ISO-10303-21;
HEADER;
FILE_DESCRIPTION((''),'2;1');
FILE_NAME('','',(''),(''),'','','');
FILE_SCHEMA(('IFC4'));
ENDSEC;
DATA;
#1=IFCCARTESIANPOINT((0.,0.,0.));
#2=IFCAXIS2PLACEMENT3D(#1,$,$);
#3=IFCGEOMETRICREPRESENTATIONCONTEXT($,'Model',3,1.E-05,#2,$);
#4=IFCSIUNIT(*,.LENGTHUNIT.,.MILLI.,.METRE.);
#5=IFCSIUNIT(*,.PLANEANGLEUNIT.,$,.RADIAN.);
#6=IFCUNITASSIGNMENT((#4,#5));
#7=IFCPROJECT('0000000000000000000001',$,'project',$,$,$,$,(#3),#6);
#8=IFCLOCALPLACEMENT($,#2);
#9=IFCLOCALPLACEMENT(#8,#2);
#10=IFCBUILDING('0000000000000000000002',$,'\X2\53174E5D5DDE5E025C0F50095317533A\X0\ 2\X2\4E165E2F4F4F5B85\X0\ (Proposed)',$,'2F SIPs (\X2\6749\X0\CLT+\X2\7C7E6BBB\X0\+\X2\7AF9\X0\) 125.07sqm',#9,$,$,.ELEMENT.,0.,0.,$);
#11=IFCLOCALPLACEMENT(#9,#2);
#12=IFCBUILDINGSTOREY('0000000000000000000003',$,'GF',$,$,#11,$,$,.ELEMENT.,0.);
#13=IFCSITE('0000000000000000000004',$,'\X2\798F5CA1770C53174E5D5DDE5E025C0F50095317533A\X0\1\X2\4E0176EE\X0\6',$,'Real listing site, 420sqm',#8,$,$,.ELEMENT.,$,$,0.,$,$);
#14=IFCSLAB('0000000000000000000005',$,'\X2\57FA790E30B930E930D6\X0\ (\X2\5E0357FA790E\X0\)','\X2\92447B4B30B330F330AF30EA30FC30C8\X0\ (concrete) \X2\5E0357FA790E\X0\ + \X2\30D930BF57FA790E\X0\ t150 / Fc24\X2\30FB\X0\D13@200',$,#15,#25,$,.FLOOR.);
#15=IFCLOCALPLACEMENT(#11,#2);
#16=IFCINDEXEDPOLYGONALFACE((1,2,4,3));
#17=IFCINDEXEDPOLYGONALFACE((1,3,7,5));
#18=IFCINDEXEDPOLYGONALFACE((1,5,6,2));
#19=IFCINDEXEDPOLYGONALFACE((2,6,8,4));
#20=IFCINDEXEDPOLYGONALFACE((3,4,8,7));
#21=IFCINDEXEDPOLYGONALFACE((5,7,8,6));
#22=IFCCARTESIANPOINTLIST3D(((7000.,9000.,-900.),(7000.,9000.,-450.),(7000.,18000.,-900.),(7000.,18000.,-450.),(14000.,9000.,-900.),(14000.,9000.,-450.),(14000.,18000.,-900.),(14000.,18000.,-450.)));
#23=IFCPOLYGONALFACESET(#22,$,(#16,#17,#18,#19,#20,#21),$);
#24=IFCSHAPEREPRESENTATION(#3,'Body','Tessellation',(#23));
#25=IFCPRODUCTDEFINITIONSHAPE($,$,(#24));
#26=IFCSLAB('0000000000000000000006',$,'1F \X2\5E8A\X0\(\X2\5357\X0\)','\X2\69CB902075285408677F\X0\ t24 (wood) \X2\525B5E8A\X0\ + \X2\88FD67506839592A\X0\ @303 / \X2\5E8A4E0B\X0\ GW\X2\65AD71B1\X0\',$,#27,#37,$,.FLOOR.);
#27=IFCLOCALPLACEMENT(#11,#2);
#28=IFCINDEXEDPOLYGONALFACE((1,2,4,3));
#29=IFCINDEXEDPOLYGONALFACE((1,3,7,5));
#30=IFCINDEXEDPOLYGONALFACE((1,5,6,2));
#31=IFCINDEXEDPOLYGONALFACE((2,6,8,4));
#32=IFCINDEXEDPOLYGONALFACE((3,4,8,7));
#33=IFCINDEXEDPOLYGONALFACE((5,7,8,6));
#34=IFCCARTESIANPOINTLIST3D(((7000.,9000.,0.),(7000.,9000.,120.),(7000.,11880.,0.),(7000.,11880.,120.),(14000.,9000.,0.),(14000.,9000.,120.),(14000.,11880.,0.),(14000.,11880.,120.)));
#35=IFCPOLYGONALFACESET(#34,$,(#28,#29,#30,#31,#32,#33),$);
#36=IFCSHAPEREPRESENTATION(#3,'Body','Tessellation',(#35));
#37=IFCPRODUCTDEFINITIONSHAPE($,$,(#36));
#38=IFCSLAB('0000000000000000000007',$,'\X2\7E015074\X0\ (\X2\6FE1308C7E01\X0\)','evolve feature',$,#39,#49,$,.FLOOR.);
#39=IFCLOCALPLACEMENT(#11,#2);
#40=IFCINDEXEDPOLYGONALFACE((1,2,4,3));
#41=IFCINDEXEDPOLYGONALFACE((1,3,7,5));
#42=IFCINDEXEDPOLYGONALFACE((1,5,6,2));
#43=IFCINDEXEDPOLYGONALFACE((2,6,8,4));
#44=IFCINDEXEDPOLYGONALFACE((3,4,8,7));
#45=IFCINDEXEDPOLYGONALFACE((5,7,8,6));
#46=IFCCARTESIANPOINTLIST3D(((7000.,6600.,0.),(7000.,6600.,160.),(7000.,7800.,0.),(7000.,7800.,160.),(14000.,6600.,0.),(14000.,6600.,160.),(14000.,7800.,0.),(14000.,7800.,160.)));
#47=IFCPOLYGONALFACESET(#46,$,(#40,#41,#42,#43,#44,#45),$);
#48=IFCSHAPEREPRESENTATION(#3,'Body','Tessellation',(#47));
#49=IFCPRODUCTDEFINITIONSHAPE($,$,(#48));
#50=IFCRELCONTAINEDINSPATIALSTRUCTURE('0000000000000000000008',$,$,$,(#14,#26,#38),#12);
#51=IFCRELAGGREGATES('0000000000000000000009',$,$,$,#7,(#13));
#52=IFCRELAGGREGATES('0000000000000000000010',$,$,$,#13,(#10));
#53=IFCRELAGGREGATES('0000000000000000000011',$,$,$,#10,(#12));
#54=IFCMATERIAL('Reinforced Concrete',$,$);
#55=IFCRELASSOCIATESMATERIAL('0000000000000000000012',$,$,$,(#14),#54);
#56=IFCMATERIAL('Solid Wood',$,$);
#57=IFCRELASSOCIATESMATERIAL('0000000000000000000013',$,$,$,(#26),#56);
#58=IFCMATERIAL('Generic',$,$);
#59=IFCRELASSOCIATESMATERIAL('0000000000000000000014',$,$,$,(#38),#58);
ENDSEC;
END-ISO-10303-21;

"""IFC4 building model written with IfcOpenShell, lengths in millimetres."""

from ifc_helpers import new_model, si_unit, frame, frame_2d, origin, place, context, project, spatial, rectangle, extrude, material, element, save


model = new_model("IFC4")

# Units and contexts
model_context = context("Model", 3, precision=1e-05, world=origin())
ifc_project = project(units=[si_unit("LENGTHUNIT", "METRE", prefix="MILLI"), si_unit("PLANEANGLEUNIT", "RADIAN")], contexts=[model_context])

# Site, building, storey
site_placement = place(None, origin())
site = spatial("IfcSite", under=ifc_project, at=site_placement, Name="福岡県北九州市小倉北区1丁目6", ObjectType="Real listing site, 420sqm", CompositionType="ELEMENT", RefElevation=0.0)
building_placement = place(site_placement, origin())
building = spatial("IfcBuilding", under=site, at=building_placement, Name="北九州市小倉北区 2世帯住宅 (Proposed)", ObjectType="2F SIPs (杉CLT+籾殻+竹) 125.07sqm", CompositionType="ELEMENT", ElevationOfRefHeight=0.0, ElevationOfTerrain=0.0)
storey_placement = place(building_placement, origin())
storey = spatial("IfcBuildingStorey", under=building, at=storey_placement, Name="GF", CompositionType="ELEMENT", Elevation=0.0)

# Slabs
ifc_material_1 = material(Name="Reinforced Concrete")
slab_1_placement = place(storey_placement, frame((3500.0, 4500.0, -450.0)))
element("IfcSlab", 1, at=slab_1_placement, inside=storey, material=ifc_material_1, Name="基礎スラブ (布基礎)", Description="鉄筋コンクリート (concrete) 布基礎 + ベタ基礎 t150 / Fc24・D13@200", PredefinedType="FLOOR", context=model_context, shape_type="SweptSolid", body=[
    extrude(rectangle(XDim=7000.0, YDim=9000.0, at=frame_2d((3500.0, 4500.0))), frame((3500.0, 4500.0, -450.0)), (0.0, 0.0, 1.0), 450.0),
])
ifc_material_2 = material(Name="Solid Wood")
slab_2_placement = place(storey_placement, frame((3500.0, 4500.0, 0.0)))
element("IfcSlab", 2, at=slab_2_placement, inside=storey, material=ifc_material_2, Name="1F 床(南)", Description="構造用合板 t24 (wood) 剛床 + 製材根太 @303 / 床下 GW断熱", PredefinedType="FLOOR", context=model_context, shape_type="SweptSolid", body=[
    extrude(rectangle(XDim=7000.0, YDim=2880.0, at=frame_2d((3500.0, 1440.0))), frame((3500.0, 4500.0, 0.0)), (0.0, 0.0, 1.0), 120.0),
])
ifc_material_3 = material(Name="Generic")
slab_3_placement = place(storey_placement, frame((3500.0, 3300.0, 0.0)))
element("IfcSlab", 3, at=slab_3_placement, inside=storey, material=ifc_material_3, Name="縁側 (濡れ縁)", Description="evolve feature", PredefinedType="FLOOR", context=model_context, shape_type="SweptSolid", body=[
    extrude(rectangle(XDim=7000.0, YDim=1200.0, at=frame_2d((3500.0, 600.0))), frame((3500.0, 3300.0, 0.0)), (0.0, 0.0, 1.0), 160.0),
])

save(model, "model.ifc")
